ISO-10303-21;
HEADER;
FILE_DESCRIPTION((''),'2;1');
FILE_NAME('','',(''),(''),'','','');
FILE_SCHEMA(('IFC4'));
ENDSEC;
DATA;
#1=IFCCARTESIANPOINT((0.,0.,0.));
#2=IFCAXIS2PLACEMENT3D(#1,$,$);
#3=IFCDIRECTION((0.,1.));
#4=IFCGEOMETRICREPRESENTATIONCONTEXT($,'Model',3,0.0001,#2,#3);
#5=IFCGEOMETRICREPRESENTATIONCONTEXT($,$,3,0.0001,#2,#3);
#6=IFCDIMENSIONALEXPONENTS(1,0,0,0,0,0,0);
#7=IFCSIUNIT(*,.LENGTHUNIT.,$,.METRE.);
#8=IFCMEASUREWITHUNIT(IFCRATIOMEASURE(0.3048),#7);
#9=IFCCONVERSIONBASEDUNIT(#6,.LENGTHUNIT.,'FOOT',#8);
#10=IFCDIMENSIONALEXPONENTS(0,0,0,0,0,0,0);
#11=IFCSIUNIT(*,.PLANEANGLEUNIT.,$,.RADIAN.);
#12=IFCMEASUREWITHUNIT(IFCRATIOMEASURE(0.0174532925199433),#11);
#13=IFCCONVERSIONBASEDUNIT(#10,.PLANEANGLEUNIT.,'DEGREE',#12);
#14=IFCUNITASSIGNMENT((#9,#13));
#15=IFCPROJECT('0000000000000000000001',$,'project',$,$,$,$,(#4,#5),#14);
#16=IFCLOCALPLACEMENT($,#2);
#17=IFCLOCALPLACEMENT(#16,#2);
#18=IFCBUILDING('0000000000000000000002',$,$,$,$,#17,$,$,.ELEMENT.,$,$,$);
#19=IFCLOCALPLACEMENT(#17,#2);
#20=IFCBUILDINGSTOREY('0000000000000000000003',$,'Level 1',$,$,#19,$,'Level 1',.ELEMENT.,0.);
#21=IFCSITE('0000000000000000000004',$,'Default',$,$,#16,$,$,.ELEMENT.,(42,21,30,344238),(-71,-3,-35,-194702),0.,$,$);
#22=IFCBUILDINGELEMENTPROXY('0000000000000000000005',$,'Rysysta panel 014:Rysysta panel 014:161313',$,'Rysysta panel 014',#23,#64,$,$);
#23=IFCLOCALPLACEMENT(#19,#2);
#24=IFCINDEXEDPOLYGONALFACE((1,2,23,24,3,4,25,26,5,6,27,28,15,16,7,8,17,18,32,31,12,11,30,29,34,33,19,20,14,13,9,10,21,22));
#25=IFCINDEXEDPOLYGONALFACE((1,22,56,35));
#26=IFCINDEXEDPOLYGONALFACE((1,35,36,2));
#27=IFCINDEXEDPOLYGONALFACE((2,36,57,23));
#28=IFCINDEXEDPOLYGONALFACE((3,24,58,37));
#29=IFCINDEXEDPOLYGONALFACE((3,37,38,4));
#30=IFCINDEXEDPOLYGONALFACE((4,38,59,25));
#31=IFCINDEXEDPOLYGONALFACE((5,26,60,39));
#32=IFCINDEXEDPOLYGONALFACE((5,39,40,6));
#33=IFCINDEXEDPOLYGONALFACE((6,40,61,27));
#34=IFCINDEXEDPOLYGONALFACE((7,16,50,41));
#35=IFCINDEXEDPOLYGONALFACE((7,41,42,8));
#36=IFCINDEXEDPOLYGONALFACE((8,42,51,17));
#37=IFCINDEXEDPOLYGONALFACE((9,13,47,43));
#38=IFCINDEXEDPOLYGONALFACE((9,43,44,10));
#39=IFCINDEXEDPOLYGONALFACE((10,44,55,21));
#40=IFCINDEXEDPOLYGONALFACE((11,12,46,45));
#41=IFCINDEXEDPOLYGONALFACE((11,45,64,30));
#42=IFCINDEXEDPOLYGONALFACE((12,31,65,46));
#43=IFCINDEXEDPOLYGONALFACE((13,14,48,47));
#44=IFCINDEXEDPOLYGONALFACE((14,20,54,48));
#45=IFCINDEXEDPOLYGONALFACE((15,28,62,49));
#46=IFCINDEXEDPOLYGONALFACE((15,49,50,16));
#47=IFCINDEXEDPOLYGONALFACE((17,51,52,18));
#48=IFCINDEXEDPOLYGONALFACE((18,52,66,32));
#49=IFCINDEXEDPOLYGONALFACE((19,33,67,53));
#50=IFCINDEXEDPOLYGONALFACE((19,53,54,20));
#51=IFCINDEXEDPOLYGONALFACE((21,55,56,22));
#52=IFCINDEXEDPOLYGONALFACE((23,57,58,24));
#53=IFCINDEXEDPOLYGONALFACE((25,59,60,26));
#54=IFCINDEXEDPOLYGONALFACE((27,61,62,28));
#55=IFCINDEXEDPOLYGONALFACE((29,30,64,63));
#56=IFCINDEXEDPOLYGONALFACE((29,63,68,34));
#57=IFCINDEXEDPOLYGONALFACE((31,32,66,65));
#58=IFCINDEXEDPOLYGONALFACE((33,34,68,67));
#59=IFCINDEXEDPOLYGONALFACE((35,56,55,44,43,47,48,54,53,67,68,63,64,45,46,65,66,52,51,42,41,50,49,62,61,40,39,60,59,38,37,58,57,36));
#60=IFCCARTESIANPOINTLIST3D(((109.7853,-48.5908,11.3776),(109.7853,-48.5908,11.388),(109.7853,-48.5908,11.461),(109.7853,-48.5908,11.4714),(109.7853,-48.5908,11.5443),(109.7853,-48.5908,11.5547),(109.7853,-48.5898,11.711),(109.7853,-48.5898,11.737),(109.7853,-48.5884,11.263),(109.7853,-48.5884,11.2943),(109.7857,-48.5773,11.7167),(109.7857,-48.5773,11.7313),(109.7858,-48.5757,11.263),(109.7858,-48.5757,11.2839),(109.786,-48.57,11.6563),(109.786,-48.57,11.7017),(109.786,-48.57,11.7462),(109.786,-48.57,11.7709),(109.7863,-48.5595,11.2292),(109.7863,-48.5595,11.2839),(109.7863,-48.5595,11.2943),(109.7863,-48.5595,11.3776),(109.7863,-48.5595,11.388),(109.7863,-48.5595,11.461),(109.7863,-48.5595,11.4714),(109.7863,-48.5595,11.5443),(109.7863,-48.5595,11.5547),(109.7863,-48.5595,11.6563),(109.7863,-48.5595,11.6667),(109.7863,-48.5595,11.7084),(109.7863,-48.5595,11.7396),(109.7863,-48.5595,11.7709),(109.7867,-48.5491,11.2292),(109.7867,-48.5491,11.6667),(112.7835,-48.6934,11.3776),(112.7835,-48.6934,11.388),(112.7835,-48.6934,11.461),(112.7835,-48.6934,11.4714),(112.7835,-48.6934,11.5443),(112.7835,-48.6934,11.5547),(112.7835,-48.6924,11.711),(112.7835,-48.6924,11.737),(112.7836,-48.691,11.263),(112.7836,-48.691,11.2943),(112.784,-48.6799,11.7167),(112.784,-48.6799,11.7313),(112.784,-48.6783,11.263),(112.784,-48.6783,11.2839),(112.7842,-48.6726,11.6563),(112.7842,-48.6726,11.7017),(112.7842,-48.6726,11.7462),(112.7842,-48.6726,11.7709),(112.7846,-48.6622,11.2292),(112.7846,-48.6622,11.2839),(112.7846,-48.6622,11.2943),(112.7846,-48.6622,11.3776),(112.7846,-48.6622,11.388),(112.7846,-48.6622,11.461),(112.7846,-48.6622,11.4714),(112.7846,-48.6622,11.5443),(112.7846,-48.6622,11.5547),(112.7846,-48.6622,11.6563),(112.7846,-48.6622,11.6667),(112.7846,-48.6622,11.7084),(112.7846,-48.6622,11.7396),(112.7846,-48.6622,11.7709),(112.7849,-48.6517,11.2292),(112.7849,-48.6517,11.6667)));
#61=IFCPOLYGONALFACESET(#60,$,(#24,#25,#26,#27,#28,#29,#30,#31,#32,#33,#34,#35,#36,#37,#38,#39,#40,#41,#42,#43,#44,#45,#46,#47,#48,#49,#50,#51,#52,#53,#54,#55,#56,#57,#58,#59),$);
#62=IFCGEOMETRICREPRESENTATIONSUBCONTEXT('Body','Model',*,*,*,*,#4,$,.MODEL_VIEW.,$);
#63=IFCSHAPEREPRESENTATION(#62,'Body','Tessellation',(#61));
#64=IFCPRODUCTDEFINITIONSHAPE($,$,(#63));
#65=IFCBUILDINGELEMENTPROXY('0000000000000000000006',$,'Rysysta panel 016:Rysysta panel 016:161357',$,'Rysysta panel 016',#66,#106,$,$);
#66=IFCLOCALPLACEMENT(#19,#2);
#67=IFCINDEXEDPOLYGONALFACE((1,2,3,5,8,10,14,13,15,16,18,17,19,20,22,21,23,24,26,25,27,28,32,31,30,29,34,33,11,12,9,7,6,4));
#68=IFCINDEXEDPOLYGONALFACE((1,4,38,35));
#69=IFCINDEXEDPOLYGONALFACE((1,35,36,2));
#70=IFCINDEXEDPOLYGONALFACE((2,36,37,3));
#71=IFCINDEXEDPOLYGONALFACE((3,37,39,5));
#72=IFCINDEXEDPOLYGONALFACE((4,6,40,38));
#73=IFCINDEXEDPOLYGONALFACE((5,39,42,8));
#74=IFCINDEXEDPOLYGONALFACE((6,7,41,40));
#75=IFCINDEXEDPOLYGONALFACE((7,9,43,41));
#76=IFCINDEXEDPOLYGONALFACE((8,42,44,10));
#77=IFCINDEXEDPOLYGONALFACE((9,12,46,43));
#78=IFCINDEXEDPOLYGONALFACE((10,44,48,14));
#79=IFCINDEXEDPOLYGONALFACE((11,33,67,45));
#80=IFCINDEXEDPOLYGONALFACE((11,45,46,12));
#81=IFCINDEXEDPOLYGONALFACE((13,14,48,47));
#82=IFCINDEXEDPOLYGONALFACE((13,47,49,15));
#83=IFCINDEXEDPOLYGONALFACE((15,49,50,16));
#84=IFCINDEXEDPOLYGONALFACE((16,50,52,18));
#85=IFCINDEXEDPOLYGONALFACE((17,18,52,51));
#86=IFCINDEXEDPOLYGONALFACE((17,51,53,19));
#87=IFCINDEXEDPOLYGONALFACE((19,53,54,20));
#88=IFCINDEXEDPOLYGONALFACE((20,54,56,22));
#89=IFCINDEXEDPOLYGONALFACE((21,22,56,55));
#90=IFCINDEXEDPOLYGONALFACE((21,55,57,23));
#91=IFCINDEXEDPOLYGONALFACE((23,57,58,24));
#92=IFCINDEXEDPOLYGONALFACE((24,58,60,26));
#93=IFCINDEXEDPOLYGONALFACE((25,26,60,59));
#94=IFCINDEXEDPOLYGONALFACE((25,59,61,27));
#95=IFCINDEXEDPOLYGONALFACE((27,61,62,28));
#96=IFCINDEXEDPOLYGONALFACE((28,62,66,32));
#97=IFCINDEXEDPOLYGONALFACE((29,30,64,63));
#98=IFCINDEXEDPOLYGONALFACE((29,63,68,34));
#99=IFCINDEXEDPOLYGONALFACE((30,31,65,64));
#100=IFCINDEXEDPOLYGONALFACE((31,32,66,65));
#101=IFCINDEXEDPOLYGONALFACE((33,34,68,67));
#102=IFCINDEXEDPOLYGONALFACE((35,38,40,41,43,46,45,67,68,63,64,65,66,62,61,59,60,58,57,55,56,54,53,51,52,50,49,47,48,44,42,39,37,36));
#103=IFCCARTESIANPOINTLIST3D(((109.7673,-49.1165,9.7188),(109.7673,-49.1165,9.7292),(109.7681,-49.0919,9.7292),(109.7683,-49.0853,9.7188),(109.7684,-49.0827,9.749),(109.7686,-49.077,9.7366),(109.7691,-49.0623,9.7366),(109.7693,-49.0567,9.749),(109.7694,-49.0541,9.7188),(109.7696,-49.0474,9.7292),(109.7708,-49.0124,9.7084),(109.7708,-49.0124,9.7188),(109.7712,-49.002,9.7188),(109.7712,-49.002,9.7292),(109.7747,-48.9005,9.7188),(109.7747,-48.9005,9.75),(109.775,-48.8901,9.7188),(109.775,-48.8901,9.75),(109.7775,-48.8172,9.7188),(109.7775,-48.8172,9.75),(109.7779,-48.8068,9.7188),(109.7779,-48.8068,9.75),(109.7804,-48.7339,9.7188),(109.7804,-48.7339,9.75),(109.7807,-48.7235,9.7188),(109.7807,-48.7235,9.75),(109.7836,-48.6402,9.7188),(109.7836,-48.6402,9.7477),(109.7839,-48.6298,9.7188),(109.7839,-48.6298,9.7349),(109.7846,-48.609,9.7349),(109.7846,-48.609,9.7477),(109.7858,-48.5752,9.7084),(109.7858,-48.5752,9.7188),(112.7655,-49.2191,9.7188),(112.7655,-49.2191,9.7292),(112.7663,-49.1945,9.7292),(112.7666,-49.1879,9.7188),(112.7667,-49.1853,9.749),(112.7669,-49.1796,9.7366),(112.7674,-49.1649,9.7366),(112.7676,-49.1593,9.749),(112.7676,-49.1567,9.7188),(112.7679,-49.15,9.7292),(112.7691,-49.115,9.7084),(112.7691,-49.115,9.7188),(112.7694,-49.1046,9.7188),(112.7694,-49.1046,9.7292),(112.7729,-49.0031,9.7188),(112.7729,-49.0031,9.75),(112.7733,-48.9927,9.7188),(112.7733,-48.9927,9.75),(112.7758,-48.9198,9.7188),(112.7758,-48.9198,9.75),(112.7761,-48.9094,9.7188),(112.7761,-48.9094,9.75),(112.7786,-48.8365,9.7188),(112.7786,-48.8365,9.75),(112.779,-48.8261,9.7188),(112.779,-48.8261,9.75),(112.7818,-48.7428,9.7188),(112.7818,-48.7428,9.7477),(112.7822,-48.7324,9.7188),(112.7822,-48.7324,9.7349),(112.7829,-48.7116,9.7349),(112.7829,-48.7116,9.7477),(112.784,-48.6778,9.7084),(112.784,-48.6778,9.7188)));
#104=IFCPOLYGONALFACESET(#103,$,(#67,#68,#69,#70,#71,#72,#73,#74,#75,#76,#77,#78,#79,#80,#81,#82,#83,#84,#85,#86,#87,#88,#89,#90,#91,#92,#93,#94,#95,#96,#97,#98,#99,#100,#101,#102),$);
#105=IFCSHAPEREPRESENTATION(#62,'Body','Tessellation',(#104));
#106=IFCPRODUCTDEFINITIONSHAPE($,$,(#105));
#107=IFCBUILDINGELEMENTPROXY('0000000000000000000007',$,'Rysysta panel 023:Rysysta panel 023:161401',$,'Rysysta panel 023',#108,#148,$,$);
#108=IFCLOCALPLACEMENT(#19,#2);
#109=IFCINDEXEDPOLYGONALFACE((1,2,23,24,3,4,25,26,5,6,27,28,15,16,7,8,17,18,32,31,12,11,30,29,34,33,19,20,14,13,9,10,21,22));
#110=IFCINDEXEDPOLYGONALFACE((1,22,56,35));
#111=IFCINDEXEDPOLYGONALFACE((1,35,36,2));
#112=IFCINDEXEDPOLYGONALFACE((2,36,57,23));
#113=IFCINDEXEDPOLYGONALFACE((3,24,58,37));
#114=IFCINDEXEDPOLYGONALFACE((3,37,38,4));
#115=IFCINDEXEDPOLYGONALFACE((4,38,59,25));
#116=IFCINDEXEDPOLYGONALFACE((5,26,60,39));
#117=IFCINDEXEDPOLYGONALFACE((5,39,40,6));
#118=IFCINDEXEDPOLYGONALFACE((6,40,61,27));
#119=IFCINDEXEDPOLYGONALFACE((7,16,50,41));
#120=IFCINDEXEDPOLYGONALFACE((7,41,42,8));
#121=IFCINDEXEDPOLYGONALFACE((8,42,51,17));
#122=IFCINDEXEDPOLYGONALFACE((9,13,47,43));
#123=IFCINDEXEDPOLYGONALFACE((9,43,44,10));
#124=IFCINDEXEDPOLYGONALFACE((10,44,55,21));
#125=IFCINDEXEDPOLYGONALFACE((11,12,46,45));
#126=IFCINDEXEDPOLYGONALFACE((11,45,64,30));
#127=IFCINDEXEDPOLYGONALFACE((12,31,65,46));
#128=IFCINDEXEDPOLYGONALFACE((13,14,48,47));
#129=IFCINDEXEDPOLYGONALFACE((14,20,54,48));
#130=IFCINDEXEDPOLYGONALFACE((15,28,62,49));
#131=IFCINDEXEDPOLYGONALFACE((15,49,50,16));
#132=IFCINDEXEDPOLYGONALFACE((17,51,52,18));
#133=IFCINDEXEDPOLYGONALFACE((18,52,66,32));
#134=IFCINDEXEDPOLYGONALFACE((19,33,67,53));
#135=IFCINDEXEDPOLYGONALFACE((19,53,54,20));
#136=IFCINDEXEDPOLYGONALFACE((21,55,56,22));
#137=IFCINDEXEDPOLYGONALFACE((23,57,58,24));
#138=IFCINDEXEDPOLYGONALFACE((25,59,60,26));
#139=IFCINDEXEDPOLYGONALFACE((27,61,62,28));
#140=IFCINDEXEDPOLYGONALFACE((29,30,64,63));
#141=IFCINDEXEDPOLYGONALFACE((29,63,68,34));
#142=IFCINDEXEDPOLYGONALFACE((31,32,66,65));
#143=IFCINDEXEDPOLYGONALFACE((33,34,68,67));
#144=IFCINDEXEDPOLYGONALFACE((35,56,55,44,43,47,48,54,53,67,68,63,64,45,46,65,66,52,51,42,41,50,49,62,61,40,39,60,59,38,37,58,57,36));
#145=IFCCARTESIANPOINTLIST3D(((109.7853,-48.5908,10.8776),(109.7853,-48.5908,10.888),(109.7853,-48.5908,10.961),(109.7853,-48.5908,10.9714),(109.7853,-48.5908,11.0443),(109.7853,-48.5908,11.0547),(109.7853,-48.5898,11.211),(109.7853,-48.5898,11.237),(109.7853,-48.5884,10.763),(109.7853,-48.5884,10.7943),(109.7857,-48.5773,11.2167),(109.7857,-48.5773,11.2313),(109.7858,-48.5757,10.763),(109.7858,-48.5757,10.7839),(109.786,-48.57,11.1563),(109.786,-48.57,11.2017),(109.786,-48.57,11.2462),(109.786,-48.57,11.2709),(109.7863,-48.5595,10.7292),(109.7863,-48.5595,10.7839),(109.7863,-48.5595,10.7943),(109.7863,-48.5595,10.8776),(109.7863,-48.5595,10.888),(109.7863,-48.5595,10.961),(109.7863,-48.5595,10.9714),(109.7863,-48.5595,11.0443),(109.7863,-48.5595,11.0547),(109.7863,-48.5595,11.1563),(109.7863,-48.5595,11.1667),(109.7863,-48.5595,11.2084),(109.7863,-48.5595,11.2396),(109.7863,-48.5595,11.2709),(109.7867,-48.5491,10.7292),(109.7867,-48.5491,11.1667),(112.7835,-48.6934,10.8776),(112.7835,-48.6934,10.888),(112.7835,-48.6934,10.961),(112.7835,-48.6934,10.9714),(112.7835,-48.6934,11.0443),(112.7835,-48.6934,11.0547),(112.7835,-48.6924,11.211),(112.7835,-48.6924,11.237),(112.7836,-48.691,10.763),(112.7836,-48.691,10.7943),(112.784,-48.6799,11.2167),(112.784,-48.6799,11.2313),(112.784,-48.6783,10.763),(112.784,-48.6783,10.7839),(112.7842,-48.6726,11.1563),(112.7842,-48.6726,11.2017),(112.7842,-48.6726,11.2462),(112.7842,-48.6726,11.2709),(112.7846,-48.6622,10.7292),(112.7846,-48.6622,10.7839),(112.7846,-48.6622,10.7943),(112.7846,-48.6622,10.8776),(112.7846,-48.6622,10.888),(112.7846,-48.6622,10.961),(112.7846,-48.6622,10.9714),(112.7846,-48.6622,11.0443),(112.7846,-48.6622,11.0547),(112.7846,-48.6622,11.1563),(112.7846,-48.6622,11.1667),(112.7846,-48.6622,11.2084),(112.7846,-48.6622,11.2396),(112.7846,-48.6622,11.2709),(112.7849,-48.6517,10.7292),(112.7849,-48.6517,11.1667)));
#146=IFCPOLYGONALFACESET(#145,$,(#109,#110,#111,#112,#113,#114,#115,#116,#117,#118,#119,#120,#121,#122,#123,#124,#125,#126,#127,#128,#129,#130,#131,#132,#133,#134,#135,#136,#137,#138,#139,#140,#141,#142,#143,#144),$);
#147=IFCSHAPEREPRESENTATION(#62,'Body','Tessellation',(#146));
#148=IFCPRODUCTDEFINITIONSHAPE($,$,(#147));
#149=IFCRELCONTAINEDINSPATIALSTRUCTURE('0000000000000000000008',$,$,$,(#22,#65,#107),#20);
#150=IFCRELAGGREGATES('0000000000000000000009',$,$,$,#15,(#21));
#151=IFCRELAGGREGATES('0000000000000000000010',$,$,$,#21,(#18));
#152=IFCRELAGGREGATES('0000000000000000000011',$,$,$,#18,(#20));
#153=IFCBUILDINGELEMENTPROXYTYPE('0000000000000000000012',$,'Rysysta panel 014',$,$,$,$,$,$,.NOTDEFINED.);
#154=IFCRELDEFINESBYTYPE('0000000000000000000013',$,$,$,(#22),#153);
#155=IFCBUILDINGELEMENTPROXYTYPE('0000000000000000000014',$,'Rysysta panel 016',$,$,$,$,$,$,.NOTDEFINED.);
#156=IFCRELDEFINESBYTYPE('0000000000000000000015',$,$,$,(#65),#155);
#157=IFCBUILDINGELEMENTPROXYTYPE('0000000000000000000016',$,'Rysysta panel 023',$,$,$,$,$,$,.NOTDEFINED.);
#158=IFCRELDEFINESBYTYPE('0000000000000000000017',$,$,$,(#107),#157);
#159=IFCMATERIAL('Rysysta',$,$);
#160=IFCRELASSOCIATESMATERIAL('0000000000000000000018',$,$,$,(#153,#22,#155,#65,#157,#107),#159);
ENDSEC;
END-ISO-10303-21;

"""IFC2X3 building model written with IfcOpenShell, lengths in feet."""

from ifc_helpers import new_model, entity, si_unit, converted_unit, direction, frame, origin, place, context, subcontext, project, spatial, polyline, outline, extrude, source, transform, mapped, material, type_object, type_shapes, element, save


model = new_model("IFC2X3")

# Units and contexts
model_context = context("Model", 3, precision=0.0001, world=origin(), true_north=direction((0.0, 1.0)))
context_of_model = context(None, 3, precision=0.0001, world=origin(), true_north=direction((0.0, 1.0)))
body_context = subcontext(model_context, "Body", "Model", "MODEL_VIEW")
ifc_project = project(units=[converted_unit("LENGTHUNIT", "FOOT", entity("IfcRatioMeasure", 0.3048), si_unit("LENGTHUNIT", "METRE"), dimensions=[1, 0, 0, 0, 0, 0, 0]), converted_unit("PLANEANGLEUNIT", "DEGREE", entity("IfcRatioMeasure", 0.0174532925199433), si_unit("PLANEANGLEUNIT", "RADIAN"), dimensions=[0, 0, 0, 0, 0, 0, 0])], contexts=[model_context, context_of_model])

# Site, building, storey
site_placement = place(None, origin())
site = spatial("IfcSite", under=ifc_project, at=site_placement, Name="Default", CompositionType="ELEMENT", RefLatitude=(42, 21, 30, 344238), RefLongitude=(-71, -3, -35, -194702), RefElevation=0.0)
building_placement = place(site_placement, origin())
building = spatial("IfcBuilding", under=site, at=building_placement, CompositionType="ELEMENT")
storey_placement = place(building_placement, origin())
storey = spatial("IfcBuildingStorey", under=building, at=storey_placement, Name="Level 1", LongName="Level 1", CompositionType="ELEMENT", Elevation=0.0)

# Building element proxies
ifc_material_1 = material(Name="Rysysta")
building_element_proxy_type_1 = type_object("IfcBuildingElementProxyType", Name="Rysysta panel 014", PredefinedType="NOTDEFINED", material=ifc_material_1)
shared_shape_1 = source(origin(), body_context, "Body", "SweptSolid", [
    extrude(outline(polyline([(-0.022, 0.1457), (-0.022, -0.2918), (-0.0116, -0.2918), (-0.0116, -0.2371), (0.0045, -0.2371), (0.0045, -0.258), (0.0173, -0.258), (0.0173, -0.2267), (-0.0116, -0.2267), (-0.0116, -0.1434), (0.0196, -0.1434), (0.0196, -0.133), (-0.0116, -0.133), (-0.0116, -0.06), (0.0196, -0.06), (0.0196, -0.0496), (-0.0116, -0.0496), (-0.0116, 0.0233), (0.0196, 0.0233), (0.0196, 0.0337), (-0.0116, 0.0337), (-0.0116, 0.1353), (-0.0012, 0.1353), (-0.0012, 0.1807), (0.0186, 0.1899), (0.0186, 0.216), (-0.0012, 0.2252), (-0.0012, 0.2498), (-0.0116, 0.2498), (-0.0116, 0.2186), (0.0062, 0.2103), (0.0062, 0.1956), (-0.0116, 0.1873), (-0.0116, 0.1457), (-0.022, 0.1457)])), frame((109.7859, -48.5711, 11.521), z_axis=(-0.999415, 0.034202, 0.0), x_axis=(-0.034202, -0.999415, 0.0)), (0.0, 0.0, -1.0), 3.0),
])
type_shapes(building_element_proxy_type_1, [shared_shape_1])
proxy_1_placement = place(storey_placement, origin())
element("IfcBuildingElementProxy", 1, at=proxy_1_placement, inside=storey, type_object=building_element_proxy_type_1, material=ifc_material_1, Name="Rysysta panel 014:Rysysta panel 014:161313", ObjectType="Rysysta panel 014", context=body_context, shape_type="MappedRepresentation", body=[
    mapped(shared_shape_1, transform((0.0, 0.0, 0.0), scale=1.0)),
])
building_element_proxy_type_2 = type_object("IfcBuildingElementProxyType", Name="Rysysta panel 016", PredefinedType="NOTDEFINED", material=ifc_material_1)
shared_shape_2 = source(origin(), body_context, "Body", "SweptSolid", [
    extrude(outline(polyline([(-0.2918, -0.0116), (-0.2918, -0.022), (0.1457, -0.022), (0.1457, -0.0116), (0.1873, -0.0116), (0.1956, 0.0062), (0.2103, 0.0062), (0.2186, -0.0116), (0.2498, -0.0116), (0.2498, -0.0012), (0.2252, -0.0012), (0.216, 0.0186), (0.1899, 0.0186), (0.1807, -0.0012), (0.1353, -0.0012), (0.1353, -0.0116), (0.0337, -0.0116), (0.0337, 0.0196), (0.0233, 0.0196), (0.0233, -0.0116), (-0.0496, -0.0116), (-0.0496, 0.0196), (-0.06, 0.0196), (-0.06, -0.0116), (-0.133, -0.0116), (-0.133, 0.0196), (-0.1434, 0.0196), (-0.1434, -0.0116), (-0.2267, -0.0116), (-0.2267, 0.0173), (-0.258, 0.0173), (-0.258, 0.0045), (-0.2371, 0.0045), (-0.2371, -0.0116), (-0.2918, -0.0116)])), frame((109.7758, -48.8668, 9.7304), z_axis=(-0.999415, 0.034202, 0.0), x_axis=(-0.034202, -0.999415, 0.0)), (0.0, 0.0, -1.0), 3.0),
])
type_shapes(building_element_proxy_type_2, [shared_shape_2])
proxy_2_placement = place(storey_placement, origin())
element("IfcBuildingElementProxy", 2, at=proxy_2_placement, inside=storey, type_object=building_element_proxy_type_2, material=ifc_material_1, Name="Rysysta panel 016:Rysysta panel 016:161357", ObjectType="Rysysta panel 016", context=body_context, shape_type="MappedRepresentation", body=[
    mapped(shared_shape_2, transform((0.0, 0.0, 0.0), scale=1.0)),
])
building_element_proxy_type_3 = type_object("IfcBuildingElementProxyType", Name="Rysysta panel 023", PredefinedType="NOTDEFINED", material=ifc_material_1)
shared_shape_3 = source(origin(), body_context, "Body", "SweptSolid", [
    extrude(outline(polyline([(-0.022, 0.1457), (-0.022, -0.2918), (-0.0116, -0.2918), (-0.0116, -0.2371), (0.0045, -0.2371), (0.0045, -0.258), (0.0173, -0.258), (0.0173, -0.2267), (-0.0116, -0.2267), (-0.0116, -0.1434), (0.0196, -0.1434), (0.0196, -0.133), (-0.0116, -0.133), (-0.0116, -0.06), (0.0196, -0.06), (0.0196, -0.0496), (-0.0116, -0.0496), (-0.0116, 0.0233), (0.0196, 0.0233), (0.0196, 0.0337), (-0.0116, 0.0337), (-0.0116, 0.1353), (-0.0012, 0.1353), (-0.0012, 0.1807), (0.0186, 0.1899), (0.0186, 0.216), (-0.0012, 0.2252), (-0.0012, 0.2498), (-0.0116, 0.2498), (-0.0116, 0.2186), (0.0062, 0.2103), (0.0062, 0.1956), (-0.0116, 0.1873), (-0.0116, 0.1457), (-0.022, 0.1457)])), frame((109.7859, -48.5711, 11.021), z_axis=(-0.999415, 0.034202, 0.0), x_axis=(-0.034202, -0.999415, 0.0)), (0.0, 0.0, -1.0), 3.0),
])
type_shapes(building_element_proxy_type_3, [shared_shape_3])
proxy_3_placement = place(storey_placement, origin())
element("IfcBuildingElementProxy", 3, at=proxy_3_placement, inside=storey, type_object=building_element_proxy_type_3, material=ifc_material_1, Name="Rysysta panel 023:Rysysta panel 023:161401", ObjectType="Rysysta panel 023", context=body_context, shape_type="MappedRepresentation", body=[
    mapped(shared_shape_3, transform((0.0, 0.0, 0.0), scale=1.0)),
])

save(model, "model.ifc")
